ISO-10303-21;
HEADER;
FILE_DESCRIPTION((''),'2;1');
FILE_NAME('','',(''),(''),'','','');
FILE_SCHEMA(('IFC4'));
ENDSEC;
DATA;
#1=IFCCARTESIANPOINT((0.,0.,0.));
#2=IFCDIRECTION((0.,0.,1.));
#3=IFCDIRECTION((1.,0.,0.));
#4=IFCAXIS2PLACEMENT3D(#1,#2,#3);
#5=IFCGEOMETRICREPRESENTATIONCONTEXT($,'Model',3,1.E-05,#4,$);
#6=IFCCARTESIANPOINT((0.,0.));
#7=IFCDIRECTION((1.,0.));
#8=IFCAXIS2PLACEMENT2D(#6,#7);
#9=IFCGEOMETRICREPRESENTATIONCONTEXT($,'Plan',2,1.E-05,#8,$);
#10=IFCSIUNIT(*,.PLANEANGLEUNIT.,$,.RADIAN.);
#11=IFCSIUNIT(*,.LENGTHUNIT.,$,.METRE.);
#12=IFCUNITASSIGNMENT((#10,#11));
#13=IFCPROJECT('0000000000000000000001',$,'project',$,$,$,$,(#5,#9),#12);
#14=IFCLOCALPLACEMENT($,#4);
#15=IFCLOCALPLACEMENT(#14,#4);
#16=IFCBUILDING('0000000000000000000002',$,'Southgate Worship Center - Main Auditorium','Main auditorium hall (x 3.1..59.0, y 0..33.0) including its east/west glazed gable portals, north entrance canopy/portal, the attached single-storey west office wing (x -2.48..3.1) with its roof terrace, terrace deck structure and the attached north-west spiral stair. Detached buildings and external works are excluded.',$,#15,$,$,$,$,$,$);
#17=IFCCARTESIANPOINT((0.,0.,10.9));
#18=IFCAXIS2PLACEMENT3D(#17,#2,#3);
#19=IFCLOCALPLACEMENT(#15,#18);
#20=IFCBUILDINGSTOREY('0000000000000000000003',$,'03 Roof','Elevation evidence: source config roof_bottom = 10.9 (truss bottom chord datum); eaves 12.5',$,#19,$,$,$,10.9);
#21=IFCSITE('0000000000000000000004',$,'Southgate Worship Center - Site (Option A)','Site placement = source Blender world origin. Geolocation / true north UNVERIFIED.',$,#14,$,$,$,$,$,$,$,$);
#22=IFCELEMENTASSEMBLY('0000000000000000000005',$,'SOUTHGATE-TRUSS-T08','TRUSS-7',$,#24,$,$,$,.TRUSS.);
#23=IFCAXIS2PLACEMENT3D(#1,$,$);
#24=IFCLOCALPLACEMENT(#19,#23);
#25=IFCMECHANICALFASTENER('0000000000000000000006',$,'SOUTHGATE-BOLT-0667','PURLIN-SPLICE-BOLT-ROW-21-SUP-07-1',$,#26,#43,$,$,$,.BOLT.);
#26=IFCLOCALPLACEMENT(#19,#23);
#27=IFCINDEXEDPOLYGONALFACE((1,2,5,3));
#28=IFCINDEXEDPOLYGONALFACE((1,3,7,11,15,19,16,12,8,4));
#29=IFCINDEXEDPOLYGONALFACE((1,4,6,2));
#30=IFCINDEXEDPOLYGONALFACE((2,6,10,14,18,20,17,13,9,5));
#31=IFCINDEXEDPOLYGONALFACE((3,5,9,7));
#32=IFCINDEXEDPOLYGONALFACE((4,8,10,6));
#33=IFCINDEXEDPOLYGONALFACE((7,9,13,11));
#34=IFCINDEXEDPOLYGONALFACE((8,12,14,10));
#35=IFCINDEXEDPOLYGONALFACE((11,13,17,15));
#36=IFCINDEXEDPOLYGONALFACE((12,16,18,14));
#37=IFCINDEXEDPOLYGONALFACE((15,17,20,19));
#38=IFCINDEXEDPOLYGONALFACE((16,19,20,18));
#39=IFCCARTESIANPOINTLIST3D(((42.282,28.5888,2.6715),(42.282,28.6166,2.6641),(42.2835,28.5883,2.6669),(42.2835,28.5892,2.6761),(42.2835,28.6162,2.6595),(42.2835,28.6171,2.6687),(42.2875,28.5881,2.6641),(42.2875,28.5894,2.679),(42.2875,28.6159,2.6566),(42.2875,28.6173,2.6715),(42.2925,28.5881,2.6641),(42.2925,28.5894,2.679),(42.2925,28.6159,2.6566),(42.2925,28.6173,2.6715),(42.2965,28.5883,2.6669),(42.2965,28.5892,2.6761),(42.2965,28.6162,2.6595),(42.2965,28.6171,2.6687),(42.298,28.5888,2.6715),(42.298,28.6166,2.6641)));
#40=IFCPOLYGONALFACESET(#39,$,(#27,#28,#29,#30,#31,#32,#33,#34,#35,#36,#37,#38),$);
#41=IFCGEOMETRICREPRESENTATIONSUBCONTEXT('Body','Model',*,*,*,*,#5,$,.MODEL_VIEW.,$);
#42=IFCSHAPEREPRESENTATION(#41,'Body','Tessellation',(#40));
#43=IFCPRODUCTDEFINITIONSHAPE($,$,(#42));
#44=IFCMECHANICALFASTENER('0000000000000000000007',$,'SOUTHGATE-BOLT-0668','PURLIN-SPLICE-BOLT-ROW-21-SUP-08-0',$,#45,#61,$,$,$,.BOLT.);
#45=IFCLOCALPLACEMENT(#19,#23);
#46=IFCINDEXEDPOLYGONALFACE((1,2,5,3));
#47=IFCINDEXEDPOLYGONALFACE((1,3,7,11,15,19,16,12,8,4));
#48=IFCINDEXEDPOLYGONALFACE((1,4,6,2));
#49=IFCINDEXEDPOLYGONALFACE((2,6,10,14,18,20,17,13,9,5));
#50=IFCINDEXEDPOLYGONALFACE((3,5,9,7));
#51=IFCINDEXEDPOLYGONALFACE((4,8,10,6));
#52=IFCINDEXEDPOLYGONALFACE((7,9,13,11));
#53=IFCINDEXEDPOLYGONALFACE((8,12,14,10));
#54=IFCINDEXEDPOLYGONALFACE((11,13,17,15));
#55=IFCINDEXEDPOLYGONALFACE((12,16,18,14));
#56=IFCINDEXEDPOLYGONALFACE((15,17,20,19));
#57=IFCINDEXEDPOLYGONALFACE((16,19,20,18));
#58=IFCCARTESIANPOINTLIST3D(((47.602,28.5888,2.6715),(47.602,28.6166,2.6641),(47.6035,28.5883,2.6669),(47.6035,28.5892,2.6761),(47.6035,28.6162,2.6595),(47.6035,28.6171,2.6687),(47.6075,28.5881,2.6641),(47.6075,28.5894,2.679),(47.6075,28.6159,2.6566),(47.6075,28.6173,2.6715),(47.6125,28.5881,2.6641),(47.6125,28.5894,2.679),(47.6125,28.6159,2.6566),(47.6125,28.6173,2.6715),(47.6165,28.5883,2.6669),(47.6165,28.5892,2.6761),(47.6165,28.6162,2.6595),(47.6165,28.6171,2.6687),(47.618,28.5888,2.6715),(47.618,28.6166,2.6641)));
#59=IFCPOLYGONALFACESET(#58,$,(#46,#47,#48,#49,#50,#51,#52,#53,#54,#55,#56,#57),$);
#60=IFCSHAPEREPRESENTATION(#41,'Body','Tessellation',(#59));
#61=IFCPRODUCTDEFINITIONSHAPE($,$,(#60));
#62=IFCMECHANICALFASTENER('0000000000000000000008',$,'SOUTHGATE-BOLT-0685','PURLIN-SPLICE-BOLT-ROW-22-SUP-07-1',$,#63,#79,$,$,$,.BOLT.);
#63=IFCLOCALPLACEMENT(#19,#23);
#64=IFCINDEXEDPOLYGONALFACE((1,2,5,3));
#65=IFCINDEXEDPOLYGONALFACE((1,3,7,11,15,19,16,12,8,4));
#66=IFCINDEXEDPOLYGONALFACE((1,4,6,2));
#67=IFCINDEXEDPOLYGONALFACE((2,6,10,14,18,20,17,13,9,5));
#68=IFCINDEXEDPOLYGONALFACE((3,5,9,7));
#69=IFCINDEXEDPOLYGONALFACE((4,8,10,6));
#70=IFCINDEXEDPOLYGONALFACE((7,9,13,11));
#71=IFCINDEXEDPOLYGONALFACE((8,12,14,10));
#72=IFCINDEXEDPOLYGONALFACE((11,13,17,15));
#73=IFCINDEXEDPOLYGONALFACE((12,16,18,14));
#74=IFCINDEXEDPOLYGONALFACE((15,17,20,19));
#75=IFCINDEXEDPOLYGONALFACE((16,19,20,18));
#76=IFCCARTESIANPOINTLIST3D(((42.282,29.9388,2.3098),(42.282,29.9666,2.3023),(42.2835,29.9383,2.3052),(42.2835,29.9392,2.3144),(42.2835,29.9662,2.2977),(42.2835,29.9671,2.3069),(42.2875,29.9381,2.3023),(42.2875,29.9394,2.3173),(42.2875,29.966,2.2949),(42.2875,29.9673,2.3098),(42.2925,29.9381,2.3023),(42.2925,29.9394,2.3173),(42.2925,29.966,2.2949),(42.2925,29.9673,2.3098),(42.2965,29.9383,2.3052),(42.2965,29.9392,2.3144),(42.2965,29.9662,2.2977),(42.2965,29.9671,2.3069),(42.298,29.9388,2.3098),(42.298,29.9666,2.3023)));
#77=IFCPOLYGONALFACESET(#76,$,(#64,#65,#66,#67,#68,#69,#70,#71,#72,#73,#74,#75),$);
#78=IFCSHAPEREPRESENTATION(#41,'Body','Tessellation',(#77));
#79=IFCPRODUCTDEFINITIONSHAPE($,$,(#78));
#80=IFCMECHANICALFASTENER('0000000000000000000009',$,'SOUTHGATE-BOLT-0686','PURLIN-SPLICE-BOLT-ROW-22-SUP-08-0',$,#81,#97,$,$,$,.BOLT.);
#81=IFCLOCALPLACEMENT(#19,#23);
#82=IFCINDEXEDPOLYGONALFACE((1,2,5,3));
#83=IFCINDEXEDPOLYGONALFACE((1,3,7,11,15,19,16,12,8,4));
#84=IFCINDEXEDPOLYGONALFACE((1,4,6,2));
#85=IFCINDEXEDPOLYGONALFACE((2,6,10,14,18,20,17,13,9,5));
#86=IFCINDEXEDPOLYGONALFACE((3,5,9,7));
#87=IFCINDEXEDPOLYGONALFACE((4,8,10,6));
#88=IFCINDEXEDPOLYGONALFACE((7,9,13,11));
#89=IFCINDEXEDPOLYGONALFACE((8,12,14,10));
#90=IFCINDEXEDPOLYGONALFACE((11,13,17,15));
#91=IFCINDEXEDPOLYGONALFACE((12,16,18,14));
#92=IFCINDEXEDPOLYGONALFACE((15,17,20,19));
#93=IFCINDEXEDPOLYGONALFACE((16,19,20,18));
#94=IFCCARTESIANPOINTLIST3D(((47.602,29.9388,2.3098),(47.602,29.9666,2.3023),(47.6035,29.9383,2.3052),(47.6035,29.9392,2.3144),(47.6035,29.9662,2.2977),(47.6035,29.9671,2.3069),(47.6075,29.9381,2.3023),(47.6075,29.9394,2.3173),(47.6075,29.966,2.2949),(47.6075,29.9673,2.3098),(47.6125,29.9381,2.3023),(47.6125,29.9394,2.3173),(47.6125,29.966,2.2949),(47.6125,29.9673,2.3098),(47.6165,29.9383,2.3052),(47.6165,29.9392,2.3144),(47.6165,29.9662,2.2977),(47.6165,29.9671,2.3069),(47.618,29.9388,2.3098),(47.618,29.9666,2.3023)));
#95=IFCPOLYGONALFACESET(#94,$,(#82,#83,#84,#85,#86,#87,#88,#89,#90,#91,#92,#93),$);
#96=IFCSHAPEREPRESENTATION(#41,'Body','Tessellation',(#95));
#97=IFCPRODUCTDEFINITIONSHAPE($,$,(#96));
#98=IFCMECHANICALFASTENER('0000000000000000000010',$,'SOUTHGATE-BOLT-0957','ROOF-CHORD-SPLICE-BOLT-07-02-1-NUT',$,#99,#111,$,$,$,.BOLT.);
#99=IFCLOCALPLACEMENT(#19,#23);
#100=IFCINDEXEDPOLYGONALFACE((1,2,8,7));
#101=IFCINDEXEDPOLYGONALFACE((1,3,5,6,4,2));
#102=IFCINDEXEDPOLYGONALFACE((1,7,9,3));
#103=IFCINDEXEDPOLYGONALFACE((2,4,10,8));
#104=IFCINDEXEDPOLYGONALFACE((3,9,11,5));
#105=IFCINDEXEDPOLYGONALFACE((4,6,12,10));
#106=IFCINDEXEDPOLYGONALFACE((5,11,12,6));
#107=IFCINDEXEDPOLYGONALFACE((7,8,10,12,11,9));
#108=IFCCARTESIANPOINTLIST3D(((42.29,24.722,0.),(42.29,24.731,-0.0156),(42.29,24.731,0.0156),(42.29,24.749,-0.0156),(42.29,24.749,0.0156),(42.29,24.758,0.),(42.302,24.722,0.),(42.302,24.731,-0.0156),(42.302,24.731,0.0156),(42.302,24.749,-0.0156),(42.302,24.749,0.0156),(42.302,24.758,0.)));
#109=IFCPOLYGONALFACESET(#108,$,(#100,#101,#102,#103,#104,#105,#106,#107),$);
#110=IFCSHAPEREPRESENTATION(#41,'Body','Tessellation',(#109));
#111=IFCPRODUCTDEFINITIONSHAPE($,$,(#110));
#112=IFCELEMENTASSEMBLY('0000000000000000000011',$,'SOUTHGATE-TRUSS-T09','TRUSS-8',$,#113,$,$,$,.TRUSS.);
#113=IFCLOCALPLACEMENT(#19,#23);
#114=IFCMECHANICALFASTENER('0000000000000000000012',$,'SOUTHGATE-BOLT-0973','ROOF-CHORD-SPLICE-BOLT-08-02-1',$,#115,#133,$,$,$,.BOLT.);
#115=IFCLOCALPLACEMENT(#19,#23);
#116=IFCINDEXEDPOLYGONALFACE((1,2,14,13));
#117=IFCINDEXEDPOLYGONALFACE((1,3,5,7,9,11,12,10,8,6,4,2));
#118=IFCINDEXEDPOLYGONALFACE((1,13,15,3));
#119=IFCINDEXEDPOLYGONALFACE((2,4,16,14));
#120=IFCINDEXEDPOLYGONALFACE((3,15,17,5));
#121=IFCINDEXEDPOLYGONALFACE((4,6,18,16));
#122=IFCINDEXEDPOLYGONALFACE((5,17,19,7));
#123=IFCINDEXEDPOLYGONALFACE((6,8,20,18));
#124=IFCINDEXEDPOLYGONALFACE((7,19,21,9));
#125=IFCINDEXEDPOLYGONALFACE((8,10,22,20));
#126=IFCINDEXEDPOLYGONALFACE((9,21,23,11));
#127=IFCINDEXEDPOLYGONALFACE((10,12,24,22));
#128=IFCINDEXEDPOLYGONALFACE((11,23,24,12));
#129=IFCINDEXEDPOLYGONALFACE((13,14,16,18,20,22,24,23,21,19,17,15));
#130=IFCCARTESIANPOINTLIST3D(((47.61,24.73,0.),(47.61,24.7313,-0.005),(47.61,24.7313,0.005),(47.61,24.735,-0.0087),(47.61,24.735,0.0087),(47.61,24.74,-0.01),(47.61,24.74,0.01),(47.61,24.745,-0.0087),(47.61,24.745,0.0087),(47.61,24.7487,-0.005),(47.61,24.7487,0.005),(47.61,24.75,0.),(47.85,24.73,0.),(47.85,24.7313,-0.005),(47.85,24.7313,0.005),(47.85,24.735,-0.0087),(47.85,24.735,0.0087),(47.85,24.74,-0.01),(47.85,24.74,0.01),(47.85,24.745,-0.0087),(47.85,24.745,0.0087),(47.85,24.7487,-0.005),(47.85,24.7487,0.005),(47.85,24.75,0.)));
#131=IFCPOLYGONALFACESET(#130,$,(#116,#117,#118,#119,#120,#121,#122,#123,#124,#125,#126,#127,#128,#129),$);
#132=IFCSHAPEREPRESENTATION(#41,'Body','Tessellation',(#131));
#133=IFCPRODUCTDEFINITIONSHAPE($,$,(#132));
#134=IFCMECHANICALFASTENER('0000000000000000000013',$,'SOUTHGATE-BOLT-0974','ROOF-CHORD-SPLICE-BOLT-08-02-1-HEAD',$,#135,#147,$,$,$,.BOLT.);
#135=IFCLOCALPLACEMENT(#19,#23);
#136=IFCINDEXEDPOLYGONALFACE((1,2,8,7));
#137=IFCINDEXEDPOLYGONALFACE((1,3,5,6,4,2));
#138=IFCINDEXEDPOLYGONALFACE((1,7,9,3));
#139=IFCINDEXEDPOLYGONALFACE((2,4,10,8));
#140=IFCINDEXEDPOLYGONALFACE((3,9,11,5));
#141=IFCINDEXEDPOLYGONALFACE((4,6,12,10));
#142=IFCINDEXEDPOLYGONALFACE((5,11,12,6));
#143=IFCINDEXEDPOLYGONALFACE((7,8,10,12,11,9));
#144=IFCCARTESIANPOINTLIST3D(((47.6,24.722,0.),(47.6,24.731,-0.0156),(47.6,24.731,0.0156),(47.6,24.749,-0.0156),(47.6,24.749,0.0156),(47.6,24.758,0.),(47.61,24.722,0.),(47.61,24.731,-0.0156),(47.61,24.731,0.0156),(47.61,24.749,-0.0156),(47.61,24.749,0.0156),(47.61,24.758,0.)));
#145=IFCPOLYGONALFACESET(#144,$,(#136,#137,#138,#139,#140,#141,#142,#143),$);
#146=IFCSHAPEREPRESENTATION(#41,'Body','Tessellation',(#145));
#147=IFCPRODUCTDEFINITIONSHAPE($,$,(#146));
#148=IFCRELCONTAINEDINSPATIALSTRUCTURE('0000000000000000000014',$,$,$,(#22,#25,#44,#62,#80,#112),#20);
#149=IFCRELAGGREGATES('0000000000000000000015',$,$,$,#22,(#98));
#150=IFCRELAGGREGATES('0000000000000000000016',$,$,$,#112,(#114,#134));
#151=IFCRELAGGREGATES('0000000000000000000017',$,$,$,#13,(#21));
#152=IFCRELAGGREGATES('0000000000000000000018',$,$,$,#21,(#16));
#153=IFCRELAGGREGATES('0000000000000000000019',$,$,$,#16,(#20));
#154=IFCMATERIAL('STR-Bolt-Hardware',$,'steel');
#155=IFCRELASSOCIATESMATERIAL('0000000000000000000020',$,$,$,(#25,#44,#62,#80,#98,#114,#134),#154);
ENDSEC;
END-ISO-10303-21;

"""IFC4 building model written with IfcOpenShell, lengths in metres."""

from ifc_helpers import new_model, si_unit, frame, origin_with_axes, origin_2d_with_axis, place, context, subcontext, project, spatial, indexed_curve, outline, extrude, clip, halfspace, material, element, aggregate, save


model = new_model("IFC4")

# Units and contexts
model_context = context("Model", 3, precision=1e-05, world=origin_with_axes())
plan_context = context("Plan", 2, precision=1e-05, world=origin_2d_with_axis())
body_context = subcontext(model_context, "Body", "Model", "MODEL_VIEW")
ifc_project = project(units=[si_unit("PLANEANGLEUNIT", "RADIAN"), si_unit("LENGTHUNIT", "METRE")], contexts=[model_context, plan_context])

# Site, building, storey
site_placement = place(None, origin_with_axes())
site = spatial("IfcSite", under=ifc_project, at=site_placement, Name="Southgate Worship Center - Site (Option A)", Description="Site placement = source Blender world origin. Geolocation / true north UNVERIFIED.")
building_placement = place(site_placement, origin_with_axes())
building = spatial("IfcBuilding", under=site, at=building_placement, Name="Southgate Worship Center - Main Auditorium", Description="Main auditorium hall (x 3.1..59.0, y 0..33.0) including its east/west glazed gable portals, north entrance canopy/portal, the attached single-storey west office wing (x -2.48..3.1) with its roof terrace, terrace deck structure and the attached north-west spiral stair. Detached buildings and external works are excluded.")
storey_placement = place(building_placement, frame((0.0, 0.0, 10.9), z_axis=(0.0, 0.0, 1.0), x_axis=(1.0, 0.0, 0.0)))
storey = spatial("IfcBuildingStorey", under=building, at=storey_placement, Name="03 Roof", Description="Elevation evidence: source config roof_bottom = 10.9 (truss bottom chord datum); eaves 12.5", Elevation=10.9)

# Element assembly
assembly_1_placement = place(storey_placement, origin_with_axes())
assembly_1 = element("IfcElementAssembly", 1, at=assembly_1_placement, inside=storey, Name="SOUTHGATE-TRUSS-T08", Description="TRUSS-7", PredefinedType="TRUSS")

# Mechanical fasteners
ifc_material_1 = material(Name="STR-Bolt-Hardware", Category="steel")
mechanical_fastener_1_placement = place(storey_placement, frame((42.282, 28.5881, 2.6566), z_axis=(0.0, 0.0, 1.0), x_axis=(1.0, 0.0, 0.0)))
element("IfcMechanicalFastener", 2, at=mechanical_fastener_1_placement, inside=storey, material=ifc_material_1, Name="SOUTHGATE-BOLT-0667", Description="PURLIN-SPLICE-BOLT-ROW-21-SUP-07-1", PredefinedType="BOLT", context=body_context, shape_type="Clipping", body=[
    clip(clip(extrude(outline(indexed_curve([(0.0, 0.0), (0.004, 0.0028), (0.0055, 0.0074), (0.004, 0.0119), (0.0, 0.0148), (-0.0049, 0.0148), (-0.0089, 0.0119), (-0.0105, 0.0074), (-0.0089, 0.0028), (-0.0049, 0.0), (0.0, 0.0)], self_intersect=False)), frame((0.0055, -0.0025, 0.0081), z_axis=(0.0, 0.965924, -0.258824), x_axis=(-1.0, 0.0, 0.0)), (0.0, 0.0, 1.0), 0.0314), halfspace(frame((0.008, 0.0007, 0.0149), z_axis=(0.0, -0.995763, 0.09196), x_axis=(1.0, 0.0, 0.0)), False)), halfspace(frame((0.008, 0.0285, 0.0075), z_axis=(0.0, 0.995763, -0.09196), x_axis=(-1.0, 0.0, 0.0)), False)),
])
mechanical_fastener_2_placement = place(storey_placement, frame((47.602, 28.5881, 2.6566), z_axis=(0.0, 0.0, 1.0), x_axis=(1.0, 0.0, 0.0)))
element("IfcMechanicalFastener", 3, at=mechanical_fastener_2_placement, inside=storey, material=ifc_material_1, Name="SOUTHGATE-BOLT-0668", Description="PURLIN-SPLICE-BOLT-ROW-21-SUP-08-0", PredefinedType="BOLT", context=body_context, shape_type="Clipping", body=[
    clip(clip(extrude(outline(indexed_curve([(0.0, 0.0), (0.004, 0.0028), (0.0055, 0.0074), (0.004, 0.0119), (0.0, 0.0148), (-0.0049, 0.0148), (-0.0089, 0.0119), (-0.0105, 0.0074), (-0.0089, 0.0028), (-0.0049, 0.0), (0.0, 0.0)], self_intersect=False)), frame((0.0055, -0.0025, 0.0081), z_axis=(0.0, 0.965924, -0.258824), x_axis=(-1.0, 0.0, 0.0)), (0.0, 0.0, 1.0), 0.0314), halfspace(frame((0.008, 0.0007, 0.0149), z_axis=(0.0, -0.995763, 0.09196), x_axis=(1.0, 0.0, 0.0)), False)), halfspace(frame((0.008, 0.0285, 0.0075), z_axis=(0.0, 0.995763, -0.09196), x_axis=(-1.0, 0.0, 0.0)), False)),
])
mechanical_fastener_3_placement = place(storey_placement, frame((42.282, 29.9381, 2.2949), z_axis=(0.0, 0.0, 1.0), x_axis=(1.0, 0.0, 0.0)))
element("IfcMechanicalFastener", 4, at=mechanical_fastener_3_placement, inside=storey, material=ifc_material_1, Name="SOUTHGATE-BOLT-0685", Description="PURLIN-SPLICE-BOLT-ROW-22-SUP-07-1", PredefinedType="BOLT", context=body_context, shape_type="Clipping", body=[
    clip(clip(extrude(outline(indexed_curve([(0.0, 0.0), (0.004, 0.0028), (0.0055, 0.0074), (0.004, 0.0119), (0.0, 0.0148), (-0.0049, 0.0148), (-0.0089, 0.0119), (-0.0105, 0.0074), (-0.0089, 0.0028), (-0.0049, 0.0), (0.0, 0.0)], self_intersect=False)), frame((0.0055, -0.0025, 0.0081), z_axis=(0.0, 0.965924, -0.258824), x_axis=(-1.0, 0.0, 0.0)), (0.0, 0.0, 1.0), 0.0314), halfspace(frame((0.008, 0.0007, 0.0149), z_axis=(0.0, -0.995763, 0.09196), x_axis=(1.0, 0.0, 0.0)), False)), halfspace(frame((0.008, 0.0285, 0.0074), z_axis=(0.0, 0.995763, -0.09196), x_axis=(-1.0, 0.0, 0.0)), False)),
])
mechanical_fastener_4_placement = place(storey_placement, frame((47.602, 29.9381, 2.2949), z_axis=(0.0, 0.0, 1.0), x_axis=(1.0, 0.0, 0.0)))
element("IfcMechanicalFastener", 5, at=mechanical_fastener_4_placement, inside=storey, material=ifc_material_1, Name="SOUTHGATE-BOLT-0686", Description="PURLIN-SPLICE-BOLT-ROW-22-SUP-08-0", PredefinedType="BOLT", context=body_context, shape_type="Clipping", body=[
    clip(clip(extrude(outline(indexed_curve([(0.0, 0.0), (0.004, 0.0028), (0.0055, 0.0074), (0.004, 0.0119), (0.0, 0.0148), (-0.0049, 0.0148), (-0.0089, 0.0119), (-0.0105, 0.0074), (-0.0089, 0.0028), (-0.0049, 0.0), (0.0, 0.0)], self_intersect=False)), frame((0.0055, -0.0025, 0.0081), z_axis=(0.0, 0.965924, -0.258824), x_axis=(-1.0, 0.0, 0.0)), (0.0, 0.0, 1.0), 0.0314), halfspace(frame((0.008, 0.0007, 0.0149), z_axis=(0.0, -0.995763, 0.09196), x_axis=(1.0, 0.0, 0.0)), False)), halfspace(frame((0.008, 0.0285, 0.0074), z_axis=(0.0, 0.995763, -0.09196), x_axis=(-1.0, 0.0, 0.0)), False)),
])

# Mechanical fastener
mechanical_fastener_5_placement = place(assembly_1_placement, frame((42.29, 24.722, -0.0156), z_axis=(0.0, 0.0, 1.0), x_axis=(1.0, 0.0, 0.0)))
mechanical_fastener_5 = element("IfcMechanicalFastener", 6, at=mechanical_fastener_5_placement, material=ifc_material_1, Name="SOUTHGATE-BOLT-0957", Description="ROOF-CHORD-SPLICE-BOLT-07-02-1-NUT", PredefinedType="BOLT", context=body_context, shape_type="SweptSolid", body=[
    extrude(outline(indexed_curve([(0.0, 0.0), (0.009, -0.0156), (0.027, -0.0156), (0.036, 0.0), (0.027, 0.0156), (0.009, 0.0156), (0.0, 0.0)], self_intersect=False)), frame((0.0, 0.0, 0.0156), z_axis=(1.0, 0.0, 0.0), x_axis=(0.0, 1.0, 0.0)), (0.0, 0.0, 1.0), 0.012),
])
aggregate(assembly_1, [mechanical_fastener_5])

# Element assembly, mechanical fasteners
assembly_2_placement = place(storey_placement, origin_with_axes())
assembly_2 = element("IfcElementAssembly", 7, at=assembly_2_placement, inside=storey, Name="SOUTHGATE-TRUSS-T09", Description="TRUSS-8", PredefinedType="TRUSS")
mechanical_fastener_6_placement = place(assembly_2_placement, frame((47.61, 24.73, -0.01), z_axis=(0.0, 0.0, 1.0), x_axis=(1.0, 0.0, 0.0)))
mechanical_fastener_6 = element("IfcMechanicalFastener", 8, at=mechanical_fastener_6_placement, material=ifc_material_1, Name="SOUTHGATE-BOLT-0973", Description="ROOF-CHORD-SPLICE-BOLT-08-02-1", PredefinedType="BOLT", context=body_context, shape_type="SweptSolid", body=[
    extrude(outline(indexed_curve([(0.0, 0.0), (0.0013, -0.005), (0.005, -0.0087), (0.01, -0.01), (0.015, -0.0087), (0.0187, -0.005), (0.02, 0.0), (0.0187, 0.005), (0.015, 0.0087), (0.01, 0.01), (0.005, 0.0087), (0.0013, 0.005), (0.0, 0.0)], self_intersect=False)), frame((0.0, 0.0, 0.01), z_axis=(1.0, 0.0, 0.0), x_axis=(0.0, 1.0, 0.0)), (0.0, 0.0, 1.0), 0.24),
])
mechanical_fastener_7_placement = place(assembly_2_placement, frame((47.6, 24.722, -0.0156), z_axis=(0.0, 0.0, 1.0), x_axis=(1.0, 0.0, 0.0)))
mechanical_fastener_7 = element("IfcMechanicalFastener", 9, at=mechanical_fastener_7_placement, material=ifc_material_1, Name="SOUTHGATE-BOLT-0974", Description="ROOF-CHORD-SPLICE-BOLT-08-02-1-HEAD", PredefinedType="BOLT", context=body_context, shape_type="SweptSolid", body=[
    extrude(outline(indexed_curve([(0.0, 0.0), (0.009, -0.0156), (0.027, -0.0156), (0.036, 0.0), (0.027, 0.0156), (0.009, 0.0156), (0.0, 0.0)], self_intersect=False)), frame((0.0, 0.0, 0.0156), z_axis=(1.0, 0.0, 0.0), x_axis=(0.0, 1.0, 0.0)), (0.0, 0.0, 1.0), 0.01),
])
aggregate(assembly_2, [mechanical_fastener_6, mechanical_fastener_7])

save(model, "model.ifc")
